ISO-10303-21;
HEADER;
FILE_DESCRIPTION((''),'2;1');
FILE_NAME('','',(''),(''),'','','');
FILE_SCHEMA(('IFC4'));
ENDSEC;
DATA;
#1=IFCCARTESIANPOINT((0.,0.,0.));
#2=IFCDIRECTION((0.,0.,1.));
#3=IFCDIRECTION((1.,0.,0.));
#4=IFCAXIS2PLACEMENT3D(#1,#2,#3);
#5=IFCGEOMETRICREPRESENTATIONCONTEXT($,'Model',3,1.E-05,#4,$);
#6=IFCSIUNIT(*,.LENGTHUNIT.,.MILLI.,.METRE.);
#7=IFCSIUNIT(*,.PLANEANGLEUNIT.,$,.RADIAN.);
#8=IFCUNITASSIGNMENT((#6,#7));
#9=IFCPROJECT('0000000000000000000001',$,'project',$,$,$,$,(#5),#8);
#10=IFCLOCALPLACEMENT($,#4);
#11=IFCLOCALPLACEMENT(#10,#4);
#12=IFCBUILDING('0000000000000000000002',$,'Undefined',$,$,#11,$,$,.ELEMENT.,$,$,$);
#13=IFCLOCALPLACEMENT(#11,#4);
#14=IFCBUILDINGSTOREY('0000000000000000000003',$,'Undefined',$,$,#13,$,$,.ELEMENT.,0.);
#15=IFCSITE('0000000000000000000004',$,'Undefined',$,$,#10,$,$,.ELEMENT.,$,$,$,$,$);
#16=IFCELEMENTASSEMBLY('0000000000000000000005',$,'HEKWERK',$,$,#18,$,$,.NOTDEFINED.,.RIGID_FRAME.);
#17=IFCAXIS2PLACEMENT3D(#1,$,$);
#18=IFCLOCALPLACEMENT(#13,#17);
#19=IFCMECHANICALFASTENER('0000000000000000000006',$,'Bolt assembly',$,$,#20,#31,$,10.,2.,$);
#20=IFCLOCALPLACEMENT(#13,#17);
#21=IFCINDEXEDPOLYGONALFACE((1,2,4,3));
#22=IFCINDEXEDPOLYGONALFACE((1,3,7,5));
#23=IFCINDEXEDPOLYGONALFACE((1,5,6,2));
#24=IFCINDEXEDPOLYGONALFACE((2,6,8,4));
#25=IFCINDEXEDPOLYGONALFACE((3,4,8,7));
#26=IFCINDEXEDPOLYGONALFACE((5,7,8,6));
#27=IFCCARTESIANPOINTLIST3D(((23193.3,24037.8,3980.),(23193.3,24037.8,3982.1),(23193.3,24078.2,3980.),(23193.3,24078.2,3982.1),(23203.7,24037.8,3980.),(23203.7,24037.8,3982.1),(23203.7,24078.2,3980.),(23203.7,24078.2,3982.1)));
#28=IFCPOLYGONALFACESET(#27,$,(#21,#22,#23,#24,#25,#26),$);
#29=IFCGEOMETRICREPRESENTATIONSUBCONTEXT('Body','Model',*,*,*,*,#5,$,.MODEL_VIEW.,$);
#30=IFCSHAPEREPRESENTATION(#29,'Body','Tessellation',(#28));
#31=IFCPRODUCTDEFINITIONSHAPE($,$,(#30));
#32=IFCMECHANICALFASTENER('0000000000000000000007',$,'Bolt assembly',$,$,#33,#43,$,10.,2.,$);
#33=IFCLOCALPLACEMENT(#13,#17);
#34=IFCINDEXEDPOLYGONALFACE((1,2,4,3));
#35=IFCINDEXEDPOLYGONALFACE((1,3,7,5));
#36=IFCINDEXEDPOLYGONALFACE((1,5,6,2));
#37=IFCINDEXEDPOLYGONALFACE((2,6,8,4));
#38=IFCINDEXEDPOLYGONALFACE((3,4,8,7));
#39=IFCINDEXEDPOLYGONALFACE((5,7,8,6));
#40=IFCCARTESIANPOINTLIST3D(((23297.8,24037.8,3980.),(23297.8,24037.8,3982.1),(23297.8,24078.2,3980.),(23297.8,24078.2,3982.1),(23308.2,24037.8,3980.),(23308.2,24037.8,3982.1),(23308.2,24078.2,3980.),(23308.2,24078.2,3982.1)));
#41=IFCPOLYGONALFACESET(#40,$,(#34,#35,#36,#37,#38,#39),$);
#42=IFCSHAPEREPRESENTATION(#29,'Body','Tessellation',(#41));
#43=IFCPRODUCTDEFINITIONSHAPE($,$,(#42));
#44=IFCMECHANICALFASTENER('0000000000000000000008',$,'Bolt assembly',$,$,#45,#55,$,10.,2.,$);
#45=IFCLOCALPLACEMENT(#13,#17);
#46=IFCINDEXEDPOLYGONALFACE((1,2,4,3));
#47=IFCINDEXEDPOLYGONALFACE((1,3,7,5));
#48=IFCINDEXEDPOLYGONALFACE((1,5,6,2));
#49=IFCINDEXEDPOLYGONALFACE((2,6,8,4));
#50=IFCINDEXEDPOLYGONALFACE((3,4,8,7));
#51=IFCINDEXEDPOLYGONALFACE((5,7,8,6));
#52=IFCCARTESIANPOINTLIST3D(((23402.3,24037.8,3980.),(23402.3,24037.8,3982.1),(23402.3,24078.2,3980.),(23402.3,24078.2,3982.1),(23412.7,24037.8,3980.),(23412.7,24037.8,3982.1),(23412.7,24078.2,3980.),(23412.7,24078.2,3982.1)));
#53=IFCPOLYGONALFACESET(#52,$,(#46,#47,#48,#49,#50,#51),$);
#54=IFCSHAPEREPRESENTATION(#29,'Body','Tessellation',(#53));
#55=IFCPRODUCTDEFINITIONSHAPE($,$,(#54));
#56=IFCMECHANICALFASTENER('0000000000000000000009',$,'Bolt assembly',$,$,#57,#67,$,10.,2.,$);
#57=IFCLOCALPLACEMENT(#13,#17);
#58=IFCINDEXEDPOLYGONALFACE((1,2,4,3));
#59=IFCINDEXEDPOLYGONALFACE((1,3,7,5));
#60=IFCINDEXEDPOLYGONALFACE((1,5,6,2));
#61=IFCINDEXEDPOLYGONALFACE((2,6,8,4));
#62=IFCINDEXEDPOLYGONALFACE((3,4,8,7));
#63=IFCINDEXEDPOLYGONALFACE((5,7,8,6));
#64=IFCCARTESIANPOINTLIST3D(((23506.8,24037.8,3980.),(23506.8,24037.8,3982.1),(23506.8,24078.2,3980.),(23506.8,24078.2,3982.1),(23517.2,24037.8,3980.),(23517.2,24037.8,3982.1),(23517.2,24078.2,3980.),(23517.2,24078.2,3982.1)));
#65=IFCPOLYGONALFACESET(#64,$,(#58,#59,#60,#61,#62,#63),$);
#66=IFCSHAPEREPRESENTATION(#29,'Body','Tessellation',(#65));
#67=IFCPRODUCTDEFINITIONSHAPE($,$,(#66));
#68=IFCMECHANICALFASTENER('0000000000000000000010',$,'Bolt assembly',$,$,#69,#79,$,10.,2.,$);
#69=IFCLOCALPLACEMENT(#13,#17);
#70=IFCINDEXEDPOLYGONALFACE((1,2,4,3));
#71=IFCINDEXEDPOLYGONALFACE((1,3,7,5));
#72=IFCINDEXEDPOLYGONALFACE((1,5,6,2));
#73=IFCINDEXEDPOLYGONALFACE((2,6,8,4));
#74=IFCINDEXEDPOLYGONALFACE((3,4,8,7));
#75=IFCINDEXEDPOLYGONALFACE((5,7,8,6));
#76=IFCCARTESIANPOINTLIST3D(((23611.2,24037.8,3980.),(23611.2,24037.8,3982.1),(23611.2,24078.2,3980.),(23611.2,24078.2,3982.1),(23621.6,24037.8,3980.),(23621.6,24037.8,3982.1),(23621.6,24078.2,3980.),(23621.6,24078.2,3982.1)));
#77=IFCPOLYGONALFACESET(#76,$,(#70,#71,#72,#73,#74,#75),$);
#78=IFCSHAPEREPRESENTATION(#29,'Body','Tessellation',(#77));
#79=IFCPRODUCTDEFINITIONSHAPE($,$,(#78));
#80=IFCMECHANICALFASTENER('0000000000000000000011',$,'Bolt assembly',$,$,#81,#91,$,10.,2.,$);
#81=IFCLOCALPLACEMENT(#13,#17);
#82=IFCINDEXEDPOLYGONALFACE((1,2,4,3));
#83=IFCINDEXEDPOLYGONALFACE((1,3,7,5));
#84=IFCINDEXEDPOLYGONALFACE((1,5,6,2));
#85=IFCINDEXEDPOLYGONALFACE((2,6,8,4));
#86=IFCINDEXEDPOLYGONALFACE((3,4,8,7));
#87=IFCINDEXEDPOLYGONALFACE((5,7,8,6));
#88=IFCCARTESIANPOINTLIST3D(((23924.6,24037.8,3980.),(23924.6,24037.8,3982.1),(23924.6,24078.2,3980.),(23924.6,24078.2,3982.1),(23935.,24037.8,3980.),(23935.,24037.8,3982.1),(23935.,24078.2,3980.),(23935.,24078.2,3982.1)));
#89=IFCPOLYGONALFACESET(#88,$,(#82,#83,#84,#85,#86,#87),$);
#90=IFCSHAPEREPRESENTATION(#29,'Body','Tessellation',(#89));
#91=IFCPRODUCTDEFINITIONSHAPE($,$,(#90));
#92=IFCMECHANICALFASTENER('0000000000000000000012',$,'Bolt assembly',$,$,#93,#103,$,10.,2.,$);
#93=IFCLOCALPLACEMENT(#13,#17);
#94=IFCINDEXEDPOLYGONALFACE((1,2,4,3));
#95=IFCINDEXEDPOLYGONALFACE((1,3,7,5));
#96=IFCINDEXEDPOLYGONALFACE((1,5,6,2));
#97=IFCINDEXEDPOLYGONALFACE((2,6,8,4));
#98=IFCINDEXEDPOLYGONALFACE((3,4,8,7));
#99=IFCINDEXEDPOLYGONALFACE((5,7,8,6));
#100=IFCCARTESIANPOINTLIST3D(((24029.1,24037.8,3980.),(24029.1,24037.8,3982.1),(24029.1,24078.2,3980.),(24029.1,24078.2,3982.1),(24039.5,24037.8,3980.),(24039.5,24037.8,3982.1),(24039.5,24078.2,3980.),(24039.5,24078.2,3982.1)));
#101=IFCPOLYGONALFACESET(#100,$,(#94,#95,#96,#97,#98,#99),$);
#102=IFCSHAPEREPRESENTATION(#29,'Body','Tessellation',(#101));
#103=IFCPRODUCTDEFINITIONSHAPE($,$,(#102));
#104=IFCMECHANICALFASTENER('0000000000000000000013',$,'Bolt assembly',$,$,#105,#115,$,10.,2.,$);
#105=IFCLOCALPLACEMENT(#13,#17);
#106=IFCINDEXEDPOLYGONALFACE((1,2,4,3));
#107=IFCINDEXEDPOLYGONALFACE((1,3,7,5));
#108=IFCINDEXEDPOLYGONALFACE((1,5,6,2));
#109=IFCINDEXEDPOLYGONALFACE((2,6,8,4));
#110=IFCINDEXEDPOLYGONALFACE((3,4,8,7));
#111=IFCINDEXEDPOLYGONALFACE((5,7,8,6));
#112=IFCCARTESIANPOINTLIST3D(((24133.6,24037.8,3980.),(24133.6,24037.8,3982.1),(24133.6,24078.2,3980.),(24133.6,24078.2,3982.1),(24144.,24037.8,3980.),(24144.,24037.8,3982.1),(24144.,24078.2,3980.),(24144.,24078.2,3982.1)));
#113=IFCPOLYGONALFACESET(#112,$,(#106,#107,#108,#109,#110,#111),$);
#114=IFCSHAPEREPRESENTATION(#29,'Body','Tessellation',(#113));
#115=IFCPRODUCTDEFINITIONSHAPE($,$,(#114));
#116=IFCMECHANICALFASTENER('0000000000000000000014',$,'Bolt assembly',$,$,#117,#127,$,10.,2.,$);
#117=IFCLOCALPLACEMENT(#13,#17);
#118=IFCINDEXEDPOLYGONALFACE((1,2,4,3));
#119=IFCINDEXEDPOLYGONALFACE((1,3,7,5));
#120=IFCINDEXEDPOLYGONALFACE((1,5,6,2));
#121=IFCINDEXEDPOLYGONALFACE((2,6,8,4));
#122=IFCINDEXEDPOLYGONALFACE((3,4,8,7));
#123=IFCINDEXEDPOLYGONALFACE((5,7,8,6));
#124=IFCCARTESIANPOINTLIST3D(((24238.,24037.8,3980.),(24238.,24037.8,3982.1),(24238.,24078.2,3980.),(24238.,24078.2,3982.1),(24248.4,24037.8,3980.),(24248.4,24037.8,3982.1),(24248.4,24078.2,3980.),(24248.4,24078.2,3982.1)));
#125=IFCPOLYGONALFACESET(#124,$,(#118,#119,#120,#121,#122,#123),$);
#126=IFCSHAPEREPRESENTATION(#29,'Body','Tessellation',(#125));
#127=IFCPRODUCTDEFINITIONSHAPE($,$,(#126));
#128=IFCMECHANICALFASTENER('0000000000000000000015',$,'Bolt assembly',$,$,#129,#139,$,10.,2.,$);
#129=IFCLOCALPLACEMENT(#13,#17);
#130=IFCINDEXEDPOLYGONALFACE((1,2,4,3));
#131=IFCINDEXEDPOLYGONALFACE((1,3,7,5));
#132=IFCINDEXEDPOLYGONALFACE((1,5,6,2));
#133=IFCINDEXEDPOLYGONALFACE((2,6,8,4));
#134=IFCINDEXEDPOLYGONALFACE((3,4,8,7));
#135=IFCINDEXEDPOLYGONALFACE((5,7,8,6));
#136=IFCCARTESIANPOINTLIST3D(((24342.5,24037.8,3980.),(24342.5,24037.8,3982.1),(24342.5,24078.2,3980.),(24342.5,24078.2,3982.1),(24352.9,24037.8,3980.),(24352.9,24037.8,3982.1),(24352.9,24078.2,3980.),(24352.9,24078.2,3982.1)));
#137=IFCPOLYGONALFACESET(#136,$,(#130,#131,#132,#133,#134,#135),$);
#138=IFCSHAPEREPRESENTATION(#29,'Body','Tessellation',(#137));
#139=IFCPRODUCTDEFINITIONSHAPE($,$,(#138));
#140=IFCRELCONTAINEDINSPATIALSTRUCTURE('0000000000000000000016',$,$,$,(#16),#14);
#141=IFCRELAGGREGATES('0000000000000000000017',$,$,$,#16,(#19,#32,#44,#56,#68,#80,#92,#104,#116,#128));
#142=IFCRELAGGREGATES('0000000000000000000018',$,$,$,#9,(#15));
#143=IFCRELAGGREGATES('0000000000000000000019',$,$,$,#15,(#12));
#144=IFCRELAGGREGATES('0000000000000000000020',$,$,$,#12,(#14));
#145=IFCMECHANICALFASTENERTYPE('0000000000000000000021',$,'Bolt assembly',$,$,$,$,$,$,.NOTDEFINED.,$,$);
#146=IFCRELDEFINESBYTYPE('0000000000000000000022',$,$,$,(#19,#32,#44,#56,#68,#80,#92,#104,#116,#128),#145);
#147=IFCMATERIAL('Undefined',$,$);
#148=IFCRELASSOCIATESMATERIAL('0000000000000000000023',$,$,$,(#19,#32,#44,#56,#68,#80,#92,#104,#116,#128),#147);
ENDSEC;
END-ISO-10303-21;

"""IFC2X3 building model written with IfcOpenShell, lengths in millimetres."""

from ifc_helpers import new_model, si_unit, frame, origin_with_axes, place, context, subcontext, project, spatial, polyline, segment, composite_curve, outline, extrude, source, transform, mapped, material, type_object, element, aggregate, save


model = new_model("IFC2X3")

# Units and contexts
model_context = context("Model", 3, precision=1e-05, world=origin_with_axes())
body_context = subcontext(model_context, "Body", "Model", "MODEL_VIEW")
ifc_project = project(units=[si_unit("LENGTHUNIT", "METRE", prefix="MILLI"), si_unit("PLANEANGLEUNIT", "RADIAN")], contexts=[model_context])

# Site, building, storey
site_placement = place(None, origin_with_axes())
site = spatial("IfcSite", under=ifc_project, at=site_placement, Name="Undefined", CompositionType="ELEMENT")
building_placement = place(site_placement, origin_with_axes())
building = spatial("IfcBuilding", under=site, at=building_placement, Name="Undefined", CompositionType="ELEMENT")
storey_placement = place(building_placement, origin_with_axes())
storey = spatial("IfcBuildingStorey", under=building, at=storey_placement, Name="Undefined", CompositionType="ELEMENT", Elevation=0.0)

# Element assembly
assembly_1_placement = place(storey_placement, origin_with_axes())
assembly_1 = element("IfcElementAssembly", 1, at=assembly_1_placement, inside=storey, Name="HEKWERK", AssemblyPlace="NOTDEFINED", PredefinedType="RIGID_FRAME")
ifc_material_1 = material(Name="Undefined")
mechanical_fastener_type = type_object("IfcMechanicalFastenerType", Name="Bolt assembly")

# Mechanical fasteners
shared_shape_1 = source(origin_with_axes(), body_context, "Body", "SweptSolid", [
    extrude(outline(composite_curve([segment(polyline([(-20.2, 5.2), (20.2, 5.2)]), True, "CONTINUOUS"), segment(polyline([(20.2, 5.2), (20.2, -5.2)]), True, "CONTINUOUS"), segment(polyline([(20.2, -5.2), (-20.2, -5.2)]), True, "CONTINUOUS"), segment(polyline([(-20.2, -5.2), (-20.2, 5.2)]), True, "CONTINUOUS")], self_intersect=False)), frame((0.0, -1.0, 0.0), z_axis=(0.0, 1.0, 0.0), x_axis=(1.0, 0.0, 0.0)), (0.0, 0.0, 1.0), 2.1),
])
mechanical_fastener_1_placement = place(assembly_1_placement, frame((23198.5, 24058.0, 3981.0), z_axis=(1.0, 0.0, 0.0), x_axis=(0.0, 1.0, 0.0)))
mechanical_fastener_1 = element("IfcMechanicalFastener", 2, at=mechanical_fastener_1_placement, type_object=mechanical_fastener_type, material=ifc_material_1, Name="Bolt assembly", NominalDiameter=10.0, NominalLength=2.0, context=body_context, shape_type="MappedRepresentation", body=[
    mapped(shared_shape_1, transform((0.0, 0.0, 0.0))),
])
shared_shape_2 = source(origin_with_axes(), body_context, "Body", "SweptSolid", [
    extrude(outline(composite_curve([segment(polyline([(-20.2, 5.2), (20.2, 5.2)]), True, "CONTINUOUS"), segment(polyline([(20.2, 5.2), (20.2, -5.2)]), True, "CONTINUOUS"), segment(polyline([(20.2, -5.2), (-20.2, -5.2)]), True, "CONTINUOUS"), segment(polyline([(-20.2, -5.2), (-20.2, 5.2)]), True, "CONTINUOUS")], self_intersect=False)), frame((0.0, -1.0, 0.0), z_axis=(0.0, 1.0, 0.0), x_axis=(1.0, 0.0, 0.0)), (0.0, 0.0, 1.0), 2.1),
])
mechanical_fastener_2_placement = place(assembly_1_placement, frame((23303.0, 24058.0, 3981.0), z_axis=(1.0, 0.0, 0.0), x_axis=(0.0, 1.0, 0.0)))
mechanical_fastener_2 = element("IfcMechanicalFastener", 3, at=mechanical_fastener_2_placement, type_object=mechanical_fastener_type, material=ifc_material_1, Name="Bolt assembly", NominalDiameter=10.0, NominalLength=2.0, context=body_context, shape_type="MappedRepresentation", body=[
    mapped(shared_shape_2, transform((0.0, 0.0, 0.0))),
])
shared_shape_3 = source(origin_with_axes(), body_context, "Body", "SweptSolid", [
    extrude(outline(composite_curve([segment(polyline([(-20.2, 5.2), (20.2, 5.2)]), True, "CONTINUOUS"), segment(polyline([(20.2, 5.2), (20.2, -5.2)]), True, "CONTINUOUS"), segment(polyline([(20.2, -5.2), (-20.2, -5.2)]), True, "CONTINUOUS"), segment(polyline([(-20.2, -5.2), (-20.2, 5.2)]), True, "CONTINUOUS")], self_intersect=False)), frame((0.0, -1.0, 0.0), z_axis=(0.0, 1.0, 0.0), x_axis=(1.0, 0.0, 0.0)), (0.0, 0.0, 1.0), 2.1),
])
mechanical_fastener_3_placement = place(assembly_1_placement, frame((23407.5, 24058.0, 3981.0), z_axis=(1.0, 0.0, 0.0), x_axis=(0.0, 1.0, 0.0)))
mechanical_fastener_3 = element("IfcMechanicalFastener", 4, at=mechanical_fastener_3_placement, type_object=mechanical_fastener_type, material=ifc_material_1, Name="Bolt assembly", NominalDiameter=10.0, NominalLength=2.0, context=body_context, shape_type="MappedRepresentation", body=[
    mapped(shared_shape_3, transform((0.0, 0.0, 0.0))),
])
shared_shape_4 = source(origin_with_axes(), body_context, "Body", "SweptSolid", [
    extrude(outline(composite_curve([segment(polyline([(-20.2, 5.2), (20.2, 5.2)]), True, "CONTINUOUS"), segment(polyline([(20.2, 5.2), (20.2, -5.2)]), True, "CONTINUOUS"), segment(polyline([(20.2, -5.2), (-20.2, -5.2)]), True, "CONTINUOUS"), segment(polyline([(-20.2, -5.2), (-20.2, 5.2)]), True, "CONTINUOUS")], self_intersect=False)), frame((0.0, -1.0, 0.0), z_axis=(0.0, 1.0, 0.0), x_axis=(1.0, 0.0, 0.0)), (0.0, 0.0, 1.0), 2.1),
])
mechanical_fastener_4_placement = place(assembly_1_placement, frame((23512.0, 24058.0, 3981.0), z_axis=(1.0, 0.0, 0.0), x_axis=(0.0, 1.0, 0.0)))
mechanical_fastener_4 = element("IfcMechanicalFastener", 5, at=mechanical_fastener_4_placement, type_object=mechanical_fastener_type, material=ifc_material_1, Name="Bolt assembly", NominalDiameter=10.0, NominalLength=2.0, context=body_context, shape_type="MappedRepresentation", body=[
    mapped(shared_shape_4, transform((0.0, 0.0, 0.0))),
])
shared_shape_5 = source(origin_with_axes(), body_context, "Body", "SweptSolid", [
    extrude(outline(composite_curve([segment(polyline([(-20.2, 5.2), (20.2, 5.2)]), True, "CONTINUOUS"), segment(polyline([(20.2, 5.2), (20.2, -5.2)]), True, "CONTINUOUS"), segment(polyline([(20.2, -5.2), (-20.2, -5.2)]), True, "CONTINUOUS"), segment(polyline([(-20.2, -5.2), (-20.2, 5.2)]), True, "CONTINUOUS")], self_intersect=False)), frame((0.0, -1.0, 0.0), z_axis=(0.0, 1.0, 0.0), x_axis=(1.0, 0.0, 0.0)), (0.0, 0.0, 1.0), 2.1),
])
mechanical_fastener_5_placement = place(assembly_1_placement, frame((23616.4, 24058.0, 3981.0), z_axis=(1.0, 0.0, 0.0), x_axis=(0.0, 1.0, 0.0)))
mechanical_fastener_5 = element("IfcMechanicalFastener", 6, at=mechanical_fastener_5_placement, type_object=mechanical_fastener_type, material=ifc_material_1, Name="Bolt assembly", NominalDiameter=10.0, NominalLength=2.0, context=body_context, shape_type="MappedRepresentation", body=[
    mapped(shared_shape_5, transform((0.0, 0.0, 0.0))),
])
shared_shape_6 = source(origin_with_axes(), body_context, "Body", "SweptSolid", [
    extrude(outline(composite_curve([segment(polyline([(-20.2, 5.2), (20.2, 5.2)]), True, "CONTINUOUS"), segment(polyline([(20.2, 5.2), (20.2, -5.2)]), True, "CONTINUOUS"), segment(polyline([(20.2, -5.2), (-20.2, -5.2)]), True, "CONTINUOUS"), segment(polyline([(-20.2, -5.2), (-20.2, 5.2)]), True, "CONTINUOUS")], self_intersect=False)), frame((0.0, -1.0, 0.0), z_axis=(0.0, 1.0, 0.0), x_axis=(1.0, 0.0, 0.0)), (0.0, 0.0, 1.0), 2.1),
])
mechanical_fastener_6_placement = place(assembly_1_placement, frame((23929.8, 24058.0, 3981.0), z_axis=(1.0, 0.0, 0.0), x_axis=(0.0, 1.0, 0.0)))
mechanical_fastener_6 = element("IfcMechanicalFastener", 7, at=mechanical_fastener_6_placement, type_object=mechanical_fastener_type, material=ifc_material_1, Name="Bolt assembly", NominalDiameter=10.0, NominalLength=2.0, context=body_context, shape_type="MappedRepresentation", body=[
    mapped(shared_shape_6, transform((0.0, 0.0, 0.0))),
])
shared_shape_7 = source(origin_with_axes(), body_context, "Body", "SweptSolid", [
    extrude(outline(composite_curve([segment(polyline([(-20.2, 5.2), (20.2, 5.2)]), True, "CONTINUOUS"), segment(polyline([(20.2, 5.2), (20.2, -5.2)]), True, "CONTINUOUS"), segment(polyline([(20.2, -5.2), (-20.2, -5.2)]), True, "CONTINUOUS"), segment(polyline([(-20.2, -5.2), (-20.2, 5.2)]), True, "CONTINUOUS")], self_intersect=False)), frame((0.0, -1.0, 0.0), z_axis=(0.0, 1.0, 0.0), x_axis=(1.0, 0.0, 0.0)), (0.0, 0.0, 1.0), 2.1),
])
mechanical_fastener_7_placement = place(assembly_1_placement, frame((24034.3, 24058.0, 3981.0), z_axis=(1.0, 0.0, 0.0), x_axis=(0.0, 1.0, 0.0)))
mechanical_fastener_7 = element("IfcMechanicalFastener", 8, at=mechanical_fastener_7_placement, type_object=mechanical_fastener_type, material=ifc_material_1, Name="Bolt assembly", NominalDiameter=10.0, NominalLength=2.0, context=body_context, shape_type="MappedRepresentation", body=[
    mapped(shared_shape_7, transform((0.0, 0.0, 0.0))),
])
shared_shape_8 = source(origin_with_axes(), body_context, "Body", "SweptSolid", [
    extrude(outline(composite_curve([segment(polyline([(-20.2, 5.2), (20.2, 5.2)]), True, "CONTINUOUS"), segment(polyline([(20.2, 5.2), (20.2, -5.2)]), True, "CONTINUOUS"), segment(polyline([(20.2, -5.2), (-20.2, -5.2)]), True, "CONTINUOUS"), segment(polyline([(-20.2, -5.2), (-20.2, 5.2)]), True, "CONTINUOUS")], self_intersect=False)), frame((0.0, -1.0, 0.0), z_axis=(0.0, 1.0, 0.0), x_axis=(1.0, 0.0, 0.0)), (0.0, 0.0, 1.0), 2.1),
])
mechanical_fastener_8_placement = place(assembly_1_placement, frame((24138.8, 24058.0, 3981.0), z_axis=(1.0, 0.0, 0.0), x_axis=(0.0, 1.0, 0.0)))
mechanical_fastener_8 = element("IfcMechanicalFastener", 9, at=mechanical_fastener_8_placement, type_object=mechanical_fastener_type, material=ifc_material_1, Name="Bolt assembly", NominalDiameter=10.0, NominalLength=2.0, context=body_context, shape_type="MappedRepresentation", body=[
    mapped(shared_shape_8, transform((0.0, 0.0, 0.0))),
])
shared_shape_9 = source(origin_with_axes(), body_context, "Body", "SweptSolid", [
    extrude(outline(composite_curve([segment(polyline([(-20.2, 5.2), (20.2, 5.2)]), True, "CONTINUOUS"), segment(polyline([(20.2, 5.2), (20.2, -5.2)]), True, "CONTINUOUS"), segment(polyline([(20.2, -5.2), (-20.2, -5.2)]), True, "CONTINUOUS"), segment(polyline([(-20.2, -5.2), (-20.2, 5.2)]), True, "CONTINUOUS")], self_intersect=False)), frame((0.0, -1.0, 0.0), z_axis=(0.0, 1.0, 0.0), x_axis=(1.0, 0.0, 0.0)), (0.0, 0.0, 1.0), 2.1),
])
mechanical_fastener_9_placement = place(assembly_1_placement, frame((24243.2, 24058.0, 3981.0), z_axis=(1.0, 0.0, 0.0), x_axis=(0.0, 1.0, 0.0)))
mechanical_fastener_9 = element("IfcMechanicalFastener", 10, at=mechanical_fastener_9_placement, type_object=mechanical_fastener_type, material=ifc_material_1, Name="Bolt assembly", NominalDiameter=10.0, NominalLength=2.0, context=body_context, shape_type="MappedRepresentation", body=[
    mapped(shared_shape_9, transform((0.0, 0.0, 0.0))),
])
shared_shape_10 = source(origin_with_axes(), body_context, "Body", "SweptSolid", [
    extrude(outline(composite_curve([segment(polyline([(-20.2, 5.2), (20.2, 5.2)]), True, "CONTINUOUS"), segment(polyline([(20.2, 5.2), (20.2, -5.2)]), True, "CONTINUOUS"), segment(polyline([(20.2, -5.2), (-20.2, -5.2)]), True, "CONTINUOUS"), segment(polyline([(-20.2, -5.2), (-20.2, 5.2)]), True, "CONTINUOUS")], self_intersect=False)), frame((0.0, -1.0, 0.0), z_axis=(0.0, 1.0, 0.0), x_axis=(1.0, 0.0, 0.0)), (0.0, 0.0, 1.0), 2.1),
])
mechanical_fastener_10_placement = place(assembly_1_placement, frame((24347.7, 24058.0, 3981.0), z_axis=(1.0, 0.0, 0.0), x_axis=(0.0, 1.0, 0.0)))
mechanical_fastener_10 = element("IfcMechanicalFastener", 11, at=mechanical_fastener_10_placement, type_object=mechanical_fastener_type, material=ifc_material_1, Name="Bolt assembly", NominalDiameter=10.0, NominalLength=2.0, context=body_context, shape_type="MappedRepresentation", body=[
    mapped(shared_shape_10, transform((0.0, 0.0, 0.0))),
])
aggregate(assembly_1, [mechanical_fastener_1, mechanical_fastener_2, mechanical_fastener_3, mechanical_fastener_4, mechanical_fastener_5, mechanical_fastener_6, mechanical_fastener_7, mechanical_fastener_8, mechanical_fastener_9, mechanical_fastener_10])

save(model, "model.ifc")
